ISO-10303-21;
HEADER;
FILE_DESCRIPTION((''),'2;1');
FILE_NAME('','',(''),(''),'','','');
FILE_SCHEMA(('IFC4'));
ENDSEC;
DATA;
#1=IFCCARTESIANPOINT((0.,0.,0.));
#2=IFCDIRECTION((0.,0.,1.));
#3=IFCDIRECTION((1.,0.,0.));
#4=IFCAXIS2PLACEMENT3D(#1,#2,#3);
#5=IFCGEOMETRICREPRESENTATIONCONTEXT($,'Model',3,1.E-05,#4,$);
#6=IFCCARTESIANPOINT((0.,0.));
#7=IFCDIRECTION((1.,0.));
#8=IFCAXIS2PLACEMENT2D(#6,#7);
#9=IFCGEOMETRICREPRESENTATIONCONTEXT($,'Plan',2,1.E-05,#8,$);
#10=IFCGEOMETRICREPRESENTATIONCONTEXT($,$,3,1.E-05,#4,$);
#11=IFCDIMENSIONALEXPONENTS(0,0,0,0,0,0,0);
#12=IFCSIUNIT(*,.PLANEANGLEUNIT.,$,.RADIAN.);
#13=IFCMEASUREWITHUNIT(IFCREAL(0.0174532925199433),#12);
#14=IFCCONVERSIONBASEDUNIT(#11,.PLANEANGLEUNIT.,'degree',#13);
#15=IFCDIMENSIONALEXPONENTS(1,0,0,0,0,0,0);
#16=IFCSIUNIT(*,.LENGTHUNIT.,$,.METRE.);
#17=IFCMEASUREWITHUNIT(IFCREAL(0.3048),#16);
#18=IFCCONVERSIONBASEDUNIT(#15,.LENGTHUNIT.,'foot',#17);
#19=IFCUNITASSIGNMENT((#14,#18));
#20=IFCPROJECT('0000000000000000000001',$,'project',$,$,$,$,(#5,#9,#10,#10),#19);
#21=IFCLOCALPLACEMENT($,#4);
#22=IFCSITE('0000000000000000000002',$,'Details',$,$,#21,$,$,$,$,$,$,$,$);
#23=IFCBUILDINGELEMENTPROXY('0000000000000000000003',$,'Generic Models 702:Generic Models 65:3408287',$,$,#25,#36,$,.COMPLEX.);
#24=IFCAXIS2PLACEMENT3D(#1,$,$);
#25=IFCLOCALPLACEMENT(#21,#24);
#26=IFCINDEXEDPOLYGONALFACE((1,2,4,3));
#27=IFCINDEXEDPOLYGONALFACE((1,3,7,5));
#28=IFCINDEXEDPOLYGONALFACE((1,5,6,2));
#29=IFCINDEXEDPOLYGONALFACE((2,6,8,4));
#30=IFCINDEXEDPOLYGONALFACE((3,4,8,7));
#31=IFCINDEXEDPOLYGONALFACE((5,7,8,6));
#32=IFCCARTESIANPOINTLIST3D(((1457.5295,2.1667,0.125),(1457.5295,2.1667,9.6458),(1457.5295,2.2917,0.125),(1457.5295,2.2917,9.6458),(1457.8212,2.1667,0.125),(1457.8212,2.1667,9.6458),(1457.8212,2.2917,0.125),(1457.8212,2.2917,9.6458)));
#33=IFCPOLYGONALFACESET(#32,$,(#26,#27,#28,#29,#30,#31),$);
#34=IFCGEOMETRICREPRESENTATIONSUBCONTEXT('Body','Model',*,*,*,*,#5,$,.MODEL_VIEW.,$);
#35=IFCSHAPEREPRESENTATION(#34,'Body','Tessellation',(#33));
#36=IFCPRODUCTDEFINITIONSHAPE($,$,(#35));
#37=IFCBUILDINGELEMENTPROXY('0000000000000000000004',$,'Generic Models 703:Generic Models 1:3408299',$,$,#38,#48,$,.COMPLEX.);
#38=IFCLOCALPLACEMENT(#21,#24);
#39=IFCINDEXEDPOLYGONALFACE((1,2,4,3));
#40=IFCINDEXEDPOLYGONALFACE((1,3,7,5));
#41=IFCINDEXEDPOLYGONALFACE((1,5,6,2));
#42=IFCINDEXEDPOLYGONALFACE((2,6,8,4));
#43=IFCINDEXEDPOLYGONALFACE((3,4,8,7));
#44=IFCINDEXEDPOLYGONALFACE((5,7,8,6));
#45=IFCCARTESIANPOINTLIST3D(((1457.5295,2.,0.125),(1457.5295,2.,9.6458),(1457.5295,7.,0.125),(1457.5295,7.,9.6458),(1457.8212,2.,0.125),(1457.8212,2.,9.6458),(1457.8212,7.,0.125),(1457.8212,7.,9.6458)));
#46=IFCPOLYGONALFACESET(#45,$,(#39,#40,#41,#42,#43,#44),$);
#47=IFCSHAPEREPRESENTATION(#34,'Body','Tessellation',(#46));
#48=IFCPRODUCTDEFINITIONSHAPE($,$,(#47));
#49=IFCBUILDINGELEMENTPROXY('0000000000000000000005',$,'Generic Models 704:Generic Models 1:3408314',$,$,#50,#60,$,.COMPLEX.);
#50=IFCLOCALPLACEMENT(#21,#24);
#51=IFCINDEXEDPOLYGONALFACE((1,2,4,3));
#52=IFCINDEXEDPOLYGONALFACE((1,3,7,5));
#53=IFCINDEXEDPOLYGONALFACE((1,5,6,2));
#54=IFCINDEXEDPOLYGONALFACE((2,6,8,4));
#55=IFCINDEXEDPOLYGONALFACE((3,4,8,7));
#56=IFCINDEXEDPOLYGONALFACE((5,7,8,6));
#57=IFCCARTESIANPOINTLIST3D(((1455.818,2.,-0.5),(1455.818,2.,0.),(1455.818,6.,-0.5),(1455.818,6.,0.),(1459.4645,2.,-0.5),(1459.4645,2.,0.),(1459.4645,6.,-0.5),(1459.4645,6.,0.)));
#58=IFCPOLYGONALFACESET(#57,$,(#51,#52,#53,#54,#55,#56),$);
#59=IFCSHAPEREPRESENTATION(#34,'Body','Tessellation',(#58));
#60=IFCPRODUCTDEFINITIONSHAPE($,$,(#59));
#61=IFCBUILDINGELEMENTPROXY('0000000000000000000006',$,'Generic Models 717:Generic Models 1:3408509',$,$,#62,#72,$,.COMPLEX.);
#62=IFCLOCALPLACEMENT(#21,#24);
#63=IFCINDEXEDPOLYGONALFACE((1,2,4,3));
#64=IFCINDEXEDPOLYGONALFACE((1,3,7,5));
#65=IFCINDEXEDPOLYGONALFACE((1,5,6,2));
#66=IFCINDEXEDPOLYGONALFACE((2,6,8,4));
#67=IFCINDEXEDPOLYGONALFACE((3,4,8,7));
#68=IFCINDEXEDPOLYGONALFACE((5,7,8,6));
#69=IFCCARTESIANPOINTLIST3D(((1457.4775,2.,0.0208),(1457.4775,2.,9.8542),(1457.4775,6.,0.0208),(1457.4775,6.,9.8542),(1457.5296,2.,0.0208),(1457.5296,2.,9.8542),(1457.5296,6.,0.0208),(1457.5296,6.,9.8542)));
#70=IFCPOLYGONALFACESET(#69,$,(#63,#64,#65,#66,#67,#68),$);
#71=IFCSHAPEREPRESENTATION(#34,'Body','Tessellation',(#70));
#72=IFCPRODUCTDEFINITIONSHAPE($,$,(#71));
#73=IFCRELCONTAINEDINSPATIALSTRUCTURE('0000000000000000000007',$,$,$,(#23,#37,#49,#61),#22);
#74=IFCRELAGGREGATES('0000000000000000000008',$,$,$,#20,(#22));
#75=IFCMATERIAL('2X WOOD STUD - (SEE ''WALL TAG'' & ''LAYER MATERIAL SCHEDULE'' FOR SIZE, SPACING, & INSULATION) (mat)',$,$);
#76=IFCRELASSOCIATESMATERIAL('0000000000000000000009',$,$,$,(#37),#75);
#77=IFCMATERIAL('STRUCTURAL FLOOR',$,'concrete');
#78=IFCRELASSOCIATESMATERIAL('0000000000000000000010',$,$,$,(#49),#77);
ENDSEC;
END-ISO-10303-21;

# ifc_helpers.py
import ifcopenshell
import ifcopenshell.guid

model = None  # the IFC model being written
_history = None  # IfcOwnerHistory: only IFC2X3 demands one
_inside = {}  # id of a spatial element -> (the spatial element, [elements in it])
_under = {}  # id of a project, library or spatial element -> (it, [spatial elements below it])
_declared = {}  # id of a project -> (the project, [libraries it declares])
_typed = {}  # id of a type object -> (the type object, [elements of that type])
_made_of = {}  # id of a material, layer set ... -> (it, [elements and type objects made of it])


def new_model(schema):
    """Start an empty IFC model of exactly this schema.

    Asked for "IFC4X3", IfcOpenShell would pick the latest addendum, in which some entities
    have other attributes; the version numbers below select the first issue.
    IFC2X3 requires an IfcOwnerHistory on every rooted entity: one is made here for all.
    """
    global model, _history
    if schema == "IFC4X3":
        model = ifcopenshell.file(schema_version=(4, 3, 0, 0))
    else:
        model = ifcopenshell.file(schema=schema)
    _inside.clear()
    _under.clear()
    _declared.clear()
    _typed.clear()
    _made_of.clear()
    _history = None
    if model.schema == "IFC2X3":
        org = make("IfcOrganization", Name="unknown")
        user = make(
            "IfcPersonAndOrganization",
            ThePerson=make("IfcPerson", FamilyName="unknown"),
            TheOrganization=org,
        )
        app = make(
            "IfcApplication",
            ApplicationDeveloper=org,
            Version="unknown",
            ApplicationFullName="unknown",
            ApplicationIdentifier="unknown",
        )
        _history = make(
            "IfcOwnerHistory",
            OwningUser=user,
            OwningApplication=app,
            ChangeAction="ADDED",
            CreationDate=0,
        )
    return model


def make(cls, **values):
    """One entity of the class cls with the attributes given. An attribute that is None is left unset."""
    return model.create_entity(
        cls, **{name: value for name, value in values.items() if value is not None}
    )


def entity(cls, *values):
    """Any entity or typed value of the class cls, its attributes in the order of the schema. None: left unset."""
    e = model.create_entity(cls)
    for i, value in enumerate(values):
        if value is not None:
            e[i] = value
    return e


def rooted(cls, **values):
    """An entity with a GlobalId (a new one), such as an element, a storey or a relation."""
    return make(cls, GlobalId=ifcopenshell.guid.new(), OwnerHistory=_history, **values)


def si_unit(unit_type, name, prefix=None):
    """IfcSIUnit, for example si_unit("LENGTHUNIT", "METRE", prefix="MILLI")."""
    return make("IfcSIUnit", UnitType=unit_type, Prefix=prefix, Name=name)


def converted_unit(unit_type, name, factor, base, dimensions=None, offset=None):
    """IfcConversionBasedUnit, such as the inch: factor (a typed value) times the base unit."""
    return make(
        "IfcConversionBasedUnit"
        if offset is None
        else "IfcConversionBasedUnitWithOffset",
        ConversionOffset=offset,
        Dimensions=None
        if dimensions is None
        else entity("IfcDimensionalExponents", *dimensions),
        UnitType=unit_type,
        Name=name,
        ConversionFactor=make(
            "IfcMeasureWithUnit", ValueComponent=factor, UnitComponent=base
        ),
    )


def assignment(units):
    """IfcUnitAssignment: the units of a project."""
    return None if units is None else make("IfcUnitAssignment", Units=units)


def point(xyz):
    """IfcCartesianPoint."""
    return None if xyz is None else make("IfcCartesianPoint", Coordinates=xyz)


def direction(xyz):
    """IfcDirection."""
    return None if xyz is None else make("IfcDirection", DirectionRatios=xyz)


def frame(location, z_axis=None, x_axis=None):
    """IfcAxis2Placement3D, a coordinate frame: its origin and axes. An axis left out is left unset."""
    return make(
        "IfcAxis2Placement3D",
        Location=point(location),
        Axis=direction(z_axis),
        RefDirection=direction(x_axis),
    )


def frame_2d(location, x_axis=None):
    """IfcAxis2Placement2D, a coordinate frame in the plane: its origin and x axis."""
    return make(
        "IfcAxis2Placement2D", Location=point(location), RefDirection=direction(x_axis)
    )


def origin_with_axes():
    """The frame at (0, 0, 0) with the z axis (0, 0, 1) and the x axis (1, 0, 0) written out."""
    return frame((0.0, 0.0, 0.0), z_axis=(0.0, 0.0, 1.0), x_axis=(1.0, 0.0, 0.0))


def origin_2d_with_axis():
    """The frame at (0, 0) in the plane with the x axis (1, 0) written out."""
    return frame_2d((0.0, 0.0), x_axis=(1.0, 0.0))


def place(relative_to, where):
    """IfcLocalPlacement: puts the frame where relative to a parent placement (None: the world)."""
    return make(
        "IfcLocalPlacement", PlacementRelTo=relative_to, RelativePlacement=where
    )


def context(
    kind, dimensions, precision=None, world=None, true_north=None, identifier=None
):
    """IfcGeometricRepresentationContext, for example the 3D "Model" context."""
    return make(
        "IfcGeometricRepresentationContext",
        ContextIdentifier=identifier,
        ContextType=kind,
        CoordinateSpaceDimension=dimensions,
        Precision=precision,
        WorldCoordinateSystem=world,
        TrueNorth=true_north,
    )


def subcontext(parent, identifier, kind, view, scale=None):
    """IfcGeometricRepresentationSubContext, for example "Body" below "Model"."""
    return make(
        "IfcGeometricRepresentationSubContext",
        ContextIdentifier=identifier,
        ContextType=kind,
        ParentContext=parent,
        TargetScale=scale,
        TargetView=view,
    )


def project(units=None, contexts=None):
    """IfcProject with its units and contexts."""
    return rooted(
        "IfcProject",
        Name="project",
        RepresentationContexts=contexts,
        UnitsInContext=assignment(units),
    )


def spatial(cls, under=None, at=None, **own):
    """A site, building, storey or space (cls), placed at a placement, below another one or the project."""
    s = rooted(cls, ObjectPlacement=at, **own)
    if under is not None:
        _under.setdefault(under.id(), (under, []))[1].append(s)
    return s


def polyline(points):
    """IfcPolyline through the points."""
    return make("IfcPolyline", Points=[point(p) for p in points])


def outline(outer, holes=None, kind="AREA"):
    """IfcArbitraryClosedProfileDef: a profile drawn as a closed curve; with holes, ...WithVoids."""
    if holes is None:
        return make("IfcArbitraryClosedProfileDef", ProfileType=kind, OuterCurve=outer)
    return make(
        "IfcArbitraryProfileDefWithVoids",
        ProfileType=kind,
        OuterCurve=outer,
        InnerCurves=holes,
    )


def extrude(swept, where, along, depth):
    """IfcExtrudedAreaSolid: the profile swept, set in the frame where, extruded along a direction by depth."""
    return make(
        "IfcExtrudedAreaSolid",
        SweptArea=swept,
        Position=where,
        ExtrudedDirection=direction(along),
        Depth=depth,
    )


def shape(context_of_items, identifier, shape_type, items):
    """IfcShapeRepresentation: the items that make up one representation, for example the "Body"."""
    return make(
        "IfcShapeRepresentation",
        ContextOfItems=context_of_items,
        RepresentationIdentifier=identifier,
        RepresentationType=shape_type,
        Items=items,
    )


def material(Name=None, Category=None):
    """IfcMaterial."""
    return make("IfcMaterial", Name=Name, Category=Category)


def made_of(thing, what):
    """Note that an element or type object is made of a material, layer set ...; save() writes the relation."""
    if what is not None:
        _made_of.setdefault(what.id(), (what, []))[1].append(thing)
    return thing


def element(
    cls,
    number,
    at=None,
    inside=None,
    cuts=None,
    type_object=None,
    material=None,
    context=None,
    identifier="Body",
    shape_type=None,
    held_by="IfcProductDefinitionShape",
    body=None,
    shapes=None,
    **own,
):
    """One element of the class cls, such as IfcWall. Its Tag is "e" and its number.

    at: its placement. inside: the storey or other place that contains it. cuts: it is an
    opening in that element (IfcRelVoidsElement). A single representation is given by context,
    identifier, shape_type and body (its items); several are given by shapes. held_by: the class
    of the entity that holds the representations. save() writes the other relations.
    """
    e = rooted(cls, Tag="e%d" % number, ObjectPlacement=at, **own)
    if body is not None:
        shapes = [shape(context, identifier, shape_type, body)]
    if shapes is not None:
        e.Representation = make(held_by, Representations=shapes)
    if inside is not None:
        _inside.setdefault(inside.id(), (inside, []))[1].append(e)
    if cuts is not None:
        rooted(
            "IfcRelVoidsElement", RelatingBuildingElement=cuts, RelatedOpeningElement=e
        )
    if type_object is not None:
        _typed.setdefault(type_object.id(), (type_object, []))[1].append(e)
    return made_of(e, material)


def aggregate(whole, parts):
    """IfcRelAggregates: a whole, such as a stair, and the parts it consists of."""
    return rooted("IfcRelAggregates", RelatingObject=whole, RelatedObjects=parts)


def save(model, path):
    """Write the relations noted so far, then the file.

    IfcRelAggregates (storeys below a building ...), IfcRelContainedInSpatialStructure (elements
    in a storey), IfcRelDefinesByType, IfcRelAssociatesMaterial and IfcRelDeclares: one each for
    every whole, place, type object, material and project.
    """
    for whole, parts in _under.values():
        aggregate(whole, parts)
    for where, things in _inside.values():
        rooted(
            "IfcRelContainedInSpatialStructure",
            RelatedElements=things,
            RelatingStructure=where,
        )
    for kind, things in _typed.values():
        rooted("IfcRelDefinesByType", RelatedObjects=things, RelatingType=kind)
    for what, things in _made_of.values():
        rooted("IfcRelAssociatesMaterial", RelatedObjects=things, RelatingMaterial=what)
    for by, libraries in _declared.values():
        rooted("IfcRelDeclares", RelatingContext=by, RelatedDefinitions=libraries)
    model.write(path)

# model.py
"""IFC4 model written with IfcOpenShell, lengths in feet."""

from ifc_helpers import new_model, entity, si_unit, converted_unit, frame, origin_with_axes, origin_2d_with_axis, place, context, subcontext, project, spatial, polyline, outline, extrude, material, element, save


model = new_model("IFC4")

# Units and contexts
model_context = context("Model", 3, precision=1e-05, world=origin_with_axes())
plan_context = context("Plan", 2, precision=1e-05, world=origin_2d_with_axis())
context_of_model = context(None, 3, precision=1e-05, world=origin_with_axes())
body_context = subcontext(model_context, "Body", "Model", "MODEL_VIEW")
ifc_project = project(units=[converted_unit("PLANEANGLEUNIT", "degree", entity("IfcReal", 0.0174532925199433), si_unit("PLANEANGLEUNIT", "RADIAN"), dimensions=[0, 0, 0, 0, 0, 0, 0]), converted_unit("LENGTHUNIT", "foot", entity("IfcReal", 0.3048), si_unit("LENGTHUNIT", "METRE"), dimensions=[1, 0, 0, 0, 0, 0, 0])], contexts=[model_context, plan_context, context_of_model, context_of_model])

# Site
site_placement = place(None, origin_with_axes())
site = spatial("IfcSite", under=ifc_project, at=site_placement, Name="Details")

# Building element proxies
ifc_material_1 = material(Name="2X WOOD STUD - (SEE 'WALL TAG' & 'LAYER MATERIAL SCHEDULE' FOR SIZE, SPACING, & INSULATION) (mat)")
ifc_material_2 = material(Name="STRUCTURAL FLOOR", Category="concrete")
proxy_1_placement = place(site_placement, frame((1457.5295, 2.1667, 0.125), z_axis=(0.0, 0.0, 1.0), x_axis=(1.0, 0.0, 0.0)))
element("IfcBuildingElementProxy", 1, at=proxy_1_placement, inside=site, Name="Generic Models 702:Generic Models 65:3408287", PredefinedType="COMPLEX", context=body_context, shape_type="SweptSolid", body=[
    extrude(outline(polyline([(-0.1458, -0.0625), (0.1458, -0.0625), (0.1458, 0.0625), (-0.1458, 0.0625), (-0.1458, -0.0625)])), frame((0.1458, 0.0625, 0.0), z_axis=(0.0, 0.0, -1.0), x_axis=(-1.0, 0.0, 0.0)), (0.0, 0.0, -1.0), 9.5208),
])
proxy_2_placement = place(site_placement, frame((1457.5295, 6.0, 0.125), z_axis=(0.0, -1.0, 0.0), x_axis=(0.0, 0.0, 1.0)))
element("IfcBuildingElementProxy", 2, at=proxy_2_placement, inside=site, material=ifc_material_1, Name="Generic Models 703:Generic Models 1:3408299", PredefinedType="COMPLEX", context=body_context, shape_type="SweptSolid", body=[
    extrude(outline(polyline([(-4.7604, -0.1458), (4.7604, -0.1458), (4.7604, 0.1458), (-4.7604, 0.1458), (-4.7604, -0.1458)])), frame((4.7604, -0.1458, -1.0), z_axis=(0.0, 0.0, -1.0), x_axis=(-1.0, 0.0, 0.0)), (0.0, 0.0, -1.0), 5.0),
])
proxy_3_placement = place(site_placement, frame((1455.818, 6.0, -0.5), z_axis=(0.0, -1.0, 0.0), x_axis=(0.0, 0.0, 1.0)))
element("IfcBuildingElementProxy", 3, at=proxy_3_placement, inside=site, material=ifc_material_2, Name="Generic Models 704:Generic Models 1:3408314", PredefinedType="COMPLEX", context=body_context, shape_type="SweptSolid", body=[
    extrude(outline(polyline([(-0.25, -1.8232), (0.25, -1.8232), (0.25, 1.8232), (-0.25, 1.8232), (-0.25, -1.8232)])), frame((0.25, -1.8232, 0.0), z_axis=(0.0, 0.0, -1.0), x_axis=(1.0, 0.0, 0.0)), (0.0, 0.0, -1.0), 4.0),
])
proxy_4_placement = place(site_placement, frame((1457.4775, 6.0, 0.0208), z_axis=(0.0, -1.0, 0.0), x_axis=(0.0, 0.0, 1.0)))
element("IfcBuildingElementProxy", 4, at=proxy_4_placement, inside=site, Name="Generic Models 717:Generic Models 1:3408509", PredefinedType="COMPLEX", context=body_context, shape_type="SweptSolid", body=[
    extrude(outline(polyline([(-0.026, -4.9167), (0.026, -4.9167), (0.026, 4.9167), (-0.026, 4.9167), (-0.026, -4.9167)])), frame((4.9167, -0.026, 0.0), z_axis=(0.0, 0.0, -1.0), x_axis=(0.0, -1.0, 0.0)), (0.0, 0.0, -1.0), 4.0),
])

save(model, "model.ifc")
